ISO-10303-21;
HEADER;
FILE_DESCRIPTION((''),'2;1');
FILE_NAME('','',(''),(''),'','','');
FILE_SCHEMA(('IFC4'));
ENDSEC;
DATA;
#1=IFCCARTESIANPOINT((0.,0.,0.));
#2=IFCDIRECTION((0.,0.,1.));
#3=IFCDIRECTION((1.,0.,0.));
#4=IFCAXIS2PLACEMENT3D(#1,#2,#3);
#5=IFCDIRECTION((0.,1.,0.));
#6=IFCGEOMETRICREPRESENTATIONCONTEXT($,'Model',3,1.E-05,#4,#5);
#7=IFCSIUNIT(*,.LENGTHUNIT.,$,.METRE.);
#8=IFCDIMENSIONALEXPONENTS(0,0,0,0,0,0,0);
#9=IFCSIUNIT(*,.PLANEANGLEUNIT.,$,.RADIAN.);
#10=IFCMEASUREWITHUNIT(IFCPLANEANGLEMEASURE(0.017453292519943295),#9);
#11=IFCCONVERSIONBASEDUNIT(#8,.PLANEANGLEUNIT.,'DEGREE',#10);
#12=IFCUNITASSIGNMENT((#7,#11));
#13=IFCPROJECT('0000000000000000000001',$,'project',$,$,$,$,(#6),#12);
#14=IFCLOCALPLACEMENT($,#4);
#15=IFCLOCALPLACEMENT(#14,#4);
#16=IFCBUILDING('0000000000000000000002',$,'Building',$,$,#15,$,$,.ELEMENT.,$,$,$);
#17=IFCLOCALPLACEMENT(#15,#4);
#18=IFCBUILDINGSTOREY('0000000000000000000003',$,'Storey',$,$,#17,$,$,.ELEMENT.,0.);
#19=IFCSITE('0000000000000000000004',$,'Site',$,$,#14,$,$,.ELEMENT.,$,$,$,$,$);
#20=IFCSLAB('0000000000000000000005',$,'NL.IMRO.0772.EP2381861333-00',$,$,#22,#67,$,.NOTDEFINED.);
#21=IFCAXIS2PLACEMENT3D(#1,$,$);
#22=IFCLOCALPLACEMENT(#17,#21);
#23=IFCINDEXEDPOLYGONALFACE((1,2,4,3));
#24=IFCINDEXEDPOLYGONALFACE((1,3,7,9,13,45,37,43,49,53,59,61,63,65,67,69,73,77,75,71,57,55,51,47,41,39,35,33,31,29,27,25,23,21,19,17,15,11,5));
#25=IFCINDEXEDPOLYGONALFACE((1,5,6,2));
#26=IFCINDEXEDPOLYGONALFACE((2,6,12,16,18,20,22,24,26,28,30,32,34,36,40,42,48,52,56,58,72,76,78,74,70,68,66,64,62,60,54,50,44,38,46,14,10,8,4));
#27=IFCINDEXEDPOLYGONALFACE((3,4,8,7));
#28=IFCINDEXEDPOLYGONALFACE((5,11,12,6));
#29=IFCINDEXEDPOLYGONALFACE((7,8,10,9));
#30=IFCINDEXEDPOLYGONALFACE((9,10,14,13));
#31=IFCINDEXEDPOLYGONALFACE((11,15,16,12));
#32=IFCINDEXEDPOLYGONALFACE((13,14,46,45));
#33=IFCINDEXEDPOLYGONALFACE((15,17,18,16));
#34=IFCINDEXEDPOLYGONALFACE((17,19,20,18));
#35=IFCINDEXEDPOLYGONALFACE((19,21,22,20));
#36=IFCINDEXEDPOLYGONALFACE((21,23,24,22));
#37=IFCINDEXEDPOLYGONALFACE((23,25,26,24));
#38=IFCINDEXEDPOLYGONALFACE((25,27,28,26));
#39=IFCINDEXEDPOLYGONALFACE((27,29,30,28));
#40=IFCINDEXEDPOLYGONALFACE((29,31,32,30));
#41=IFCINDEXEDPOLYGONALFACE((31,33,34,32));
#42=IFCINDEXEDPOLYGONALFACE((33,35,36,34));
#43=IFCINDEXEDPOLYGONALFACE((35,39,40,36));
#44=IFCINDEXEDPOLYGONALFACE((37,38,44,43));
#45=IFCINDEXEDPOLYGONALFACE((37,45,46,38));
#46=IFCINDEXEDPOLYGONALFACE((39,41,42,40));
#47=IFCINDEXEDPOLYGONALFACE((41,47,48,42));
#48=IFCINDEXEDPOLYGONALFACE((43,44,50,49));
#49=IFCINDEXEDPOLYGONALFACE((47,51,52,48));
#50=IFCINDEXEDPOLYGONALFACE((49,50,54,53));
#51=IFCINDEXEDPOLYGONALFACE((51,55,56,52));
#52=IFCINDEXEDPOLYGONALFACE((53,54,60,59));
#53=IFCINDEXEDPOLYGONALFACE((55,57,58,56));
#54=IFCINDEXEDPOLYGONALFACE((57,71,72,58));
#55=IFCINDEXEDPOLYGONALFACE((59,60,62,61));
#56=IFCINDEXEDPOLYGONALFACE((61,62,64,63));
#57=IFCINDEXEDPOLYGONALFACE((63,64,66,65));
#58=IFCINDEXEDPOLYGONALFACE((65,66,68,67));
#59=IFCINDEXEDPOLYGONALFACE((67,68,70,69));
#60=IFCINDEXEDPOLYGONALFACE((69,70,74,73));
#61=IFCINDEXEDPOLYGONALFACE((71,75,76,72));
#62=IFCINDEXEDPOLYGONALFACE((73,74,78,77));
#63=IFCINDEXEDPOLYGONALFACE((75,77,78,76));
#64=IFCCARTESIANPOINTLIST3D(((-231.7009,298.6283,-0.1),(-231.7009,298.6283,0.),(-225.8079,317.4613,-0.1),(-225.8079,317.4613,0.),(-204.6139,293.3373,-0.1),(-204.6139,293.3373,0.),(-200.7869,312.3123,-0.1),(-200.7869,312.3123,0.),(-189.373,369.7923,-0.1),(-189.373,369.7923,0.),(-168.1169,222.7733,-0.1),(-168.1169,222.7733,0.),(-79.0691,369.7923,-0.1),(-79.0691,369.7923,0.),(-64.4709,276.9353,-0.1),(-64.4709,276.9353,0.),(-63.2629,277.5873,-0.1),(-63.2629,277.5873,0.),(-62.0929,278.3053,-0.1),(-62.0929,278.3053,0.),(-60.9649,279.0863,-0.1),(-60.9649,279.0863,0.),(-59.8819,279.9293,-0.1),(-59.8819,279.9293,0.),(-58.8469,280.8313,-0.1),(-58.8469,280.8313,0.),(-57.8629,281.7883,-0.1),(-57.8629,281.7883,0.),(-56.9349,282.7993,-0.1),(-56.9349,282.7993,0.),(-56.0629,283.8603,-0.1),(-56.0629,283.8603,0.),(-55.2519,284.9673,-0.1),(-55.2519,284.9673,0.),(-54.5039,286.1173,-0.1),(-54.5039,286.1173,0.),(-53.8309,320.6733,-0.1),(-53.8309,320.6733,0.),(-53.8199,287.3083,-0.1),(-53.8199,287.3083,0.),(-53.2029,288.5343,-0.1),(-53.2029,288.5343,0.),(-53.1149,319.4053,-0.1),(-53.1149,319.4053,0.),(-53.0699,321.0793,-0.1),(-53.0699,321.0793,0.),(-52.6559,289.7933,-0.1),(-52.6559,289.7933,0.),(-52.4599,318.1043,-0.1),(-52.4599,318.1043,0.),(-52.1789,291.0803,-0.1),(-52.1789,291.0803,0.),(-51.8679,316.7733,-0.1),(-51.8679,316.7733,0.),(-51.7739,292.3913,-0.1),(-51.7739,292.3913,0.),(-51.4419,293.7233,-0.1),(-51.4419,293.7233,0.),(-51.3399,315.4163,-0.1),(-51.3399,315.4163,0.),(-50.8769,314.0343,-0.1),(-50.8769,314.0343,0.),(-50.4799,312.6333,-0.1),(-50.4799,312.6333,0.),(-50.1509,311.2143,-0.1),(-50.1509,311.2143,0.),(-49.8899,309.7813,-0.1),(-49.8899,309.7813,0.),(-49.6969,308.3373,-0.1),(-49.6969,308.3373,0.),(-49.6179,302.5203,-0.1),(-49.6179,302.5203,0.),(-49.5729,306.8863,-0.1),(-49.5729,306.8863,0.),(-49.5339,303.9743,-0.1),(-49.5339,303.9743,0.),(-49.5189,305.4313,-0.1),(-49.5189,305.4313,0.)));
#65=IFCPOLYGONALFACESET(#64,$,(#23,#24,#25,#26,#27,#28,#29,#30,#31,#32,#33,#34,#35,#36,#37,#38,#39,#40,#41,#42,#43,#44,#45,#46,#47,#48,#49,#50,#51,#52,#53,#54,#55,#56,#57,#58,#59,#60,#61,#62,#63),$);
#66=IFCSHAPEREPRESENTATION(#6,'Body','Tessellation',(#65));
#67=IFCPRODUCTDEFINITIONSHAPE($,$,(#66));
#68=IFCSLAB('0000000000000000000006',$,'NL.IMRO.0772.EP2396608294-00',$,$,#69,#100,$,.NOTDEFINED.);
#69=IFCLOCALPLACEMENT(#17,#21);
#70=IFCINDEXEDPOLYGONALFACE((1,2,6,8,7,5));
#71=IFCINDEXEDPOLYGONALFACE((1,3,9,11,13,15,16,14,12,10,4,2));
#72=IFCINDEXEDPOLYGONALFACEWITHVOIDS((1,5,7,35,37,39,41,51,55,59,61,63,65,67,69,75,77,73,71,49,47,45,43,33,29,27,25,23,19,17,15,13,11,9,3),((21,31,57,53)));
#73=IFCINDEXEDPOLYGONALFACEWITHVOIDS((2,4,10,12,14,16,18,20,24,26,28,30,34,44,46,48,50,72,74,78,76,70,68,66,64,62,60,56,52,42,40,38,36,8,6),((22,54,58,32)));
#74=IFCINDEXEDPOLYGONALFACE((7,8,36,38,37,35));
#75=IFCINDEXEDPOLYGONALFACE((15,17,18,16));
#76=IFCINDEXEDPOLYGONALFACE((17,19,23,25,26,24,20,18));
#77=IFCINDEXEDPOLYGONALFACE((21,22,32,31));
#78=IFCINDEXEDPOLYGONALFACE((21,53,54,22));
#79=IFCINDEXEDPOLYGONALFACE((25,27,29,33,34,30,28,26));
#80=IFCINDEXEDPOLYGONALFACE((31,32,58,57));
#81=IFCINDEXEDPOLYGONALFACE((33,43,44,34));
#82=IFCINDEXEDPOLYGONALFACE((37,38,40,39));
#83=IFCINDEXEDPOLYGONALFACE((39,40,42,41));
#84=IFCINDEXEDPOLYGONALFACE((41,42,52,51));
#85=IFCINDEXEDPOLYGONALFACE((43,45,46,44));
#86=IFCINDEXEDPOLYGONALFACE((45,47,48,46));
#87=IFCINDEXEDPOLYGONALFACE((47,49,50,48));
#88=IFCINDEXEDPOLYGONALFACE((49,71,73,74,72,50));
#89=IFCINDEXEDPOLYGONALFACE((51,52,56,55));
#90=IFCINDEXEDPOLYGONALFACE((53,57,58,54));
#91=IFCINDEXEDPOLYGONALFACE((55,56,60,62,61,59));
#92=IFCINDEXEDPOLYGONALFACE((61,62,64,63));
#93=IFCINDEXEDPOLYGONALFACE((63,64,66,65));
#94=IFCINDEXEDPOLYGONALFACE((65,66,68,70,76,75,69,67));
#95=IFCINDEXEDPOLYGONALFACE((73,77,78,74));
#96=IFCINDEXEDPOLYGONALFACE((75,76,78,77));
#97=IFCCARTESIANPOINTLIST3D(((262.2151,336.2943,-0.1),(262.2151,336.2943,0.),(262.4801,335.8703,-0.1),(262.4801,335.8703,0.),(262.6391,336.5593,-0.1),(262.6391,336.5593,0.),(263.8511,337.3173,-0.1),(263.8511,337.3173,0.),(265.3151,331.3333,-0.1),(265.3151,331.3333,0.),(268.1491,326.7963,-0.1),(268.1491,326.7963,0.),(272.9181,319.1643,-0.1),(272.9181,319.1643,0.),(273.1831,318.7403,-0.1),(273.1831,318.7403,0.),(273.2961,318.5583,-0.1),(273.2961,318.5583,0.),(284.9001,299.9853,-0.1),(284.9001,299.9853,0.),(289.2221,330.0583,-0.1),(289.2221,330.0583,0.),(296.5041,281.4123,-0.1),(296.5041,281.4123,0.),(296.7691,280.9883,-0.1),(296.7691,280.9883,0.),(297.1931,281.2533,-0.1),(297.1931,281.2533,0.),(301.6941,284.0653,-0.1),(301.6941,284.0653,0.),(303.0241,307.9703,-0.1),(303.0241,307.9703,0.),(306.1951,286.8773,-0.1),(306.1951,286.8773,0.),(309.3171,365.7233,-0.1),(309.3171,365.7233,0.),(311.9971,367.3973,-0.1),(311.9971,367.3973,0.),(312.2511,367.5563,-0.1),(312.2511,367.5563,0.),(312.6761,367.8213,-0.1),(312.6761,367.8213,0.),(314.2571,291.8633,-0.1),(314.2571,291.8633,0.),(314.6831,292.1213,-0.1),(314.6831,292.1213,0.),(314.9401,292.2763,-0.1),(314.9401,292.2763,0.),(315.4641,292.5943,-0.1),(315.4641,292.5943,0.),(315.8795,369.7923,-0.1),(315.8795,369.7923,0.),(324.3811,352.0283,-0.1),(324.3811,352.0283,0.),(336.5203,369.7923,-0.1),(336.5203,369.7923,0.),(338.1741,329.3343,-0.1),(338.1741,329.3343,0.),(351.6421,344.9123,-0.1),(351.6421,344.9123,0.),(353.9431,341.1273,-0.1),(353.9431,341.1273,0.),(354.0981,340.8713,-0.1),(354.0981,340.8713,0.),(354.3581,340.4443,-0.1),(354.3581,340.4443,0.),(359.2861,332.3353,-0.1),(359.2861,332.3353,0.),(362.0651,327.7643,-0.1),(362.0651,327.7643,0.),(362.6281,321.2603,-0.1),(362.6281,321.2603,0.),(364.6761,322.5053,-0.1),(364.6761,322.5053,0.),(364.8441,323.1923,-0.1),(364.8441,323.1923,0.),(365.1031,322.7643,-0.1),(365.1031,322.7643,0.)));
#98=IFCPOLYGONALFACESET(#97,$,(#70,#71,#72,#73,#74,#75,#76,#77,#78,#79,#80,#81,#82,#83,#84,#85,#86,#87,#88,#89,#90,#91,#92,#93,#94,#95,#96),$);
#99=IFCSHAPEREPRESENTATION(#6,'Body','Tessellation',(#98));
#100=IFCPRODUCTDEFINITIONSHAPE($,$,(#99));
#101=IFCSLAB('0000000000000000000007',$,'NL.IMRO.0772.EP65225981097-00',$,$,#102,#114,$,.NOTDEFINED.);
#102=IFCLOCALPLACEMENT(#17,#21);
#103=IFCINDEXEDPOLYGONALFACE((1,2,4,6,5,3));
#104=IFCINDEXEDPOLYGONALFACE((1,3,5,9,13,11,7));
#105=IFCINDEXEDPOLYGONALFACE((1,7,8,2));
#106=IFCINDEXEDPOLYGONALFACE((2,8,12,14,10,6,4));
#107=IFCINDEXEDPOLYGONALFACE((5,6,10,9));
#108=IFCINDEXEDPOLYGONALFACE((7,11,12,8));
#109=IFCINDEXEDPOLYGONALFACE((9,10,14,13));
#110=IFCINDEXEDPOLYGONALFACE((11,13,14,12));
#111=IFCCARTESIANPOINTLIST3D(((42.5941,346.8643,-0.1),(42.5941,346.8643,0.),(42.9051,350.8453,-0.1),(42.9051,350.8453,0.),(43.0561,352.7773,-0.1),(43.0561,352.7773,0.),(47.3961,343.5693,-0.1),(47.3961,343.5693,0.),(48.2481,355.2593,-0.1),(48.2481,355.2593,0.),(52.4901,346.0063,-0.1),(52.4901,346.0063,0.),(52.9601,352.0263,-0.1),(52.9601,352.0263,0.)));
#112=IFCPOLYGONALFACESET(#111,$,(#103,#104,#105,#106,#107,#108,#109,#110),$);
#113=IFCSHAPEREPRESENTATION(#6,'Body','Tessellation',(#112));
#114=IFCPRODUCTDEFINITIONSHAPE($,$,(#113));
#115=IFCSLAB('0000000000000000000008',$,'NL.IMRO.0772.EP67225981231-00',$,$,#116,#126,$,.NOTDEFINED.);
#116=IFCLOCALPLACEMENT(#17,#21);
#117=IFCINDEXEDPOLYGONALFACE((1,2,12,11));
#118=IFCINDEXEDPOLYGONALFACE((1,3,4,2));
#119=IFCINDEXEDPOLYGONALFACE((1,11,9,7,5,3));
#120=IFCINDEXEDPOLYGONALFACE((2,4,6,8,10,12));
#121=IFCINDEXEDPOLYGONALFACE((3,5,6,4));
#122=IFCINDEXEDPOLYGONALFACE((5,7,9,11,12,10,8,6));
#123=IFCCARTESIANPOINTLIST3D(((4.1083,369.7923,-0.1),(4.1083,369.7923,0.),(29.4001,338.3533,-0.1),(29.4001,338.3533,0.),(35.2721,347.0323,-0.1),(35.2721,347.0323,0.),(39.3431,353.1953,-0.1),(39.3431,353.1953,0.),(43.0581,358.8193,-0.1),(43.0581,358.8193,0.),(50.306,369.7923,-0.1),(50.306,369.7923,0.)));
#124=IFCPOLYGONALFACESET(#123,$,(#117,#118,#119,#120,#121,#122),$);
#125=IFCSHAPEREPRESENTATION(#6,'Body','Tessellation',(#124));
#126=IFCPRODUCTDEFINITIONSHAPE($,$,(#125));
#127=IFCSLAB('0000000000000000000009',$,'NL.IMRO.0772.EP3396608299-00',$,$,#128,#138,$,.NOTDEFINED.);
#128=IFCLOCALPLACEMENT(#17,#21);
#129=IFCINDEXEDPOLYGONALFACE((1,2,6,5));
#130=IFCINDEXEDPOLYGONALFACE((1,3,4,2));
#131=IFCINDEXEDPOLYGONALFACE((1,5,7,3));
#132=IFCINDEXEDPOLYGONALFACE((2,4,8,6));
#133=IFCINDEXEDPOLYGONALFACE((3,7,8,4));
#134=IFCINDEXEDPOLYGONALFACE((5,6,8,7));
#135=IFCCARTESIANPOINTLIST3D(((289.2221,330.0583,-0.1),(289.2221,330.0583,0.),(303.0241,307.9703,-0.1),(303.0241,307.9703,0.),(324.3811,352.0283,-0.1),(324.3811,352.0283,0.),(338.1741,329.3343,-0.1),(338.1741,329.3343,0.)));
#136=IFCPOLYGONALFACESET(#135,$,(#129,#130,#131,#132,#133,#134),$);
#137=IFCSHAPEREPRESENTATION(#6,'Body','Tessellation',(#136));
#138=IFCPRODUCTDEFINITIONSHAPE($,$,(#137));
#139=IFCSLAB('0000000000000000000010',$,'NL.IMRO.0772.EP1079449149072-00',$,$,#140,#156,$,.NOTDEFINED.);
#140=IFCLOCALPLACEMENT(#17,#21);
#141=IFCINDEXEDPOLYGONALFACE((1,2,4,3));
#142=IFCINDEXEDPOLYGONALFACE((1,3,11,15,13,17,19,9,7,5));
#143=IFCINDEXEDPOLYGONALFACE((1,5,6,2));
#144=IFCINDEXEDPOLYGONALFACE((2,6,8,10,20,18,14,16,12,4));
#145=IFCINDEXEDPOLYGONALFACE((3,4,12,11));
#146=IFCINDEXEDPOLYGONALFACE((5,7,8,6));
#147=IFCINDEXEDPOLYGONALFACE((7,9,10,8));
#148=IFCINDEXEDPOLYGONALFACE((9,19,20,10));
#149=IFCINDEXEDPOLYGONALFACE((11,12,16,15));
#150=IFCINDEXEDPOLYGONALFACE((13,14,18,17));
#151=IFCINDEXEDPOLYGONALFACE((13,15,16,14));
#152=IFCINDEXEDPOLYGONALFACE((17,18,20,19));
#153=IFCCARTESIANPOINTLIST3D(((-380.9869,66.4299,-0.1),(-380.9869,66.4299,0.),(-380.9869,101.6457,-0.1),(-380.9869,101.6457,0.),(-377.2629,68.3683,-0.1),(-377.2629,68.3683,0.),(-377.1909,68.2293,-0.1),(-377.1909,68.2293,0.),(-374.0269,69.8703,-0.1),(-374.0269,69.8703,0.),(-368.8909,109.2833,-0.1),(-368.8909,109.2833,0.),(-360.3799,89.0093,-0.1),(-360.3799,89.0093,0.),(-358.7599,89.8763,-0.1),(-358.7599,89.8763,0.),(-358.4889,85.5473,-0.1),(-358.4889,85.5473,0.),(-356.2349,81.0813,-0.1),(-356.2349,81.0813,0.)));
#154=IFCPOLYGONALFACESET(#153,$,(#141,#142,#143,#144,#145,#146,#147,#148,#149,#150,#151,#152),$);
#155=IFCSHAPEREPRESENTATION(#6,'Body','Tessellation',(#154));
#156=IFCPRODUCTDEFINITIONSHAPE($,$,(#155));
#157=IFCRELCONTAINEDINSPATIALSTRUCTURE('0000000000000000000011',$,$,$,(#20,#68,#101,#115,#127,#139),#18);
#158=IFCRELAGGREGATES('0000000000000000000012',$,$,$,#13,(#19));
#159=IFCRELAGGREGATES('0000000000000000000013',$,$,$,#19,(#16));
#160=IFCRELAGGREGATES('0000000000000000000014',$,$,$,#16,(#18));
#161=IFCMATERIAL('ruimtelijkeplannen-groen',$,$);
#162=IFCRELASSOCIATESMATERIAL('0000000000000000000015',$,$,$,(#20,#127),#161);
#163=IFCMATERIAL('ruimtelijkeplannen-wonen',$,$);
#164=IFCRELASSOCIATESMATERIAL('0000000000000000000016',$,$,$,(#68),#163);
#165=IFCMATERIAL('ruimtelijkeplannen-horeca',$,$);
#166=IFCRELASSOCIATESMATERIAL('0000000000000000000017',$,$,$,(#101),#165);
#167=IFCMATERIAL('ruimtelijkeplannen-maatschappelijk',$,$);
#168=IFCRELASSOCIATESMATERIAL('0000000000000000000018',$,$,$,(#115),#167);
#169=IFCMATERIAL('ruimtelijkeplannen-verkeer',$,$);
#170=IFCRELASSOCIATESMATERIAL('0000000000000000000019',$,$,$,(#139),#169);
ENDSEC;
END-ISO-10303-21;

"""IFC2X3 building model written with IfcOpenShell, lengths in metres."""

from ifc_helpers import new_model, entity, si_unit, converted_unit, direction, frame, origin_with_axes, place, context, project, spatial, polyline, outline, extrude, material, element, save


model = new_model("IFC2X3")

# Units and contexts
model_context = context("Model", 3, precision=1e-05, world=origin_with_axes(), true_north=direction((0.0, 1.0, 0.0)))
ifc_project = project(units=[si_unit("LENGTHUNIT", "METRE"), converted_unit("PLANEANGLEUNIT", "DEGREE", entity("IfcPlaneAngleMeasure", 0.017453292519943295), si_unit("PLANEANGLEUNIT", "RADIAN"), dimensions=[0, 0, 0, 0, 0, 0, 0])], contexts=[model_context])

# Site, building, storey
site_placement = place(None, origin_with_axes())
site = spatial("IfcSite", under=ifc_project, at=site_placement, Name="Site", CompositionType="ELEMENT")
building_placement = place(site_placement, origin_with_axes())
building = spatial("IfcBuilding", under=site, at=building_placement, Name="Building", CompositionType="ELEMENT")
storey_placement = place(building_placement, origin_with_axes())
storey = spatial("IfcBuildingStorey", under=building, at=storey_placement, Name="Storey", CompositionType="ELEMENT", Elevation=0.0)

# Slabs
ifc_material_1 = material(Name="ruimtelijkeplannen-wonen")
ifc_material_2 = material(Name="ruimtelijkeplannen-groen")
slab_1_placement = place(storey_placement, frame((0.0, 0.0, -0.1), z_axis=(0.0, 0.0, 1.0), x_axis=(1.0, 0.0, 0.0)))
element("IfcSlab", 1, at=slab_1_placement, inside=storey, material=ifc_material_2, Name="NL.IMRO.0772.EP2381861333-00", PredefinedType="NOTDEFINED", context=model_context, shape_type="SweptSolid", body=[
    extrude(outline(polyline([(-53.0699, 321.0793), (-53.8309, 320.6733), (-53.1149, 319.4053), (-52.4599, 318.1043), (-51.8679, 316.7733), (-51.3399, 315.4163), (-50.8769, 314.0343), (-50.4799, 312.6333), (-50.1509, 311.2143), (-49.8899, 309.7813), (-49.6969, 308.3373), (-49.5729, 306.8863), (-49.5189, 305.4313), (-49.5339, 303.9743), (-49.6179, 302.5203), (-51.4419, 293.7233), (-51.7739, 292.3913), (-52.1789, 291.0803), (-52.6559, 289.7933), (-53.2029, 288.5343), (-53.8199, 287.3083), (-54.5039, 286.1173), (-55.2519, 284.9673), (-56.0629, 283.8603), (-56.9349, 282.7993), (-57.8629, 281.7883), (-58.8469, 280.8313), (-59.8819, 279.9293), (-60.9649, 279.0863), (-62.0929, 278.3053), (-63.2629, 277.5873), (-64.4709, 276.9353), (-168.1169, 222.7733), (-204.6139, 293.3373), (-231.7009, 298.6283), (-225.8079, 317.4613), (-200.7869, 312.3123), (-189.373, 369.7923), (-79.0691, 369.7923), (-53.0699, 321.0793)])), origin_with_axes(), (0.0, 0.0, 1.0), 0.1),
])
ifc_material_3 = material(Name="ruimtelijkeplannen-verkeer")
slab_2_placement = place(storey_placement, frame((0.0, 0.0, -0.1), z_axis=(0.0, 0.0, 1.0), x_axis=(1.0, 0.0, 0.0)))
element("IfcSlab", 2, at=slab_2_placement, inside=storey, material=ifc_material_1, Name="NL.IMRO.0772.EP2396608294-00", PredefinedType="NOTDEFINED", context=model_context, shape_type="SweptSolid", body=[
    extrude(outline(polyline([(351.6421, 344.9123), (353.9431, 341.1273), (354.0981, 340.8713), (354.3581, 340.4443), (359.2861, 332.3353), (362.0651, 327.7643), (364.8441, 323.1923), (365.1031, 322.7643), (364.6761, 322.5053), (362.6281, 321.2603), (315.4641, 292.5943), (314.9401, 292.2763), (314.6831, 292.1213), (314.2571, 291.8633), (306.1951, 286.8773), (301.6941, 284.0653), (297.1931, 281.2533), (296.7691, 280.9883), (296.5041, 281.4123), (284.9001, 299.9853), (273.2961, 318.5583), (273.1831, 318.7403), (272.9181, 319.1643), (268.1491, 326.7963), (265.3151, 331.3333), (262.4801, 335.8703), (262.2151, 336.2943), (262.6391, 336.5593), (263.8511, 337.3173), (309.3171, 365.7233), (311.9971, 367.3973), (312.2511, 367.5563), (312.6761, 367.8213), (315.8795, 369.7923), (336.5203, 369.7923), (351.6421, 344.9123)]), holes=[polyline([(303.0241, 307.9703), (338.1741, 329.3343), (324.3811, 352.0283), (289.2221, 330.0583), (303.0241, 307.9703)])]), origin_with_axes(), (0.0, 0.0, 1.0), 0.1),
])
ifc_material_4 = material(Name="ruimtelijkeplannen-horeca")
slab_3_placement = place(storey_placement, frame((0.0, 0.0, -0.1), z_axis=(0.0, 0.0, 1.0), x_axis=(1.0, 0.0, 0.0)))
element("IfcSlab", 3, at=slab_3_placement, inside=storey, material=ifc_material_4, Name="NL.IMRO.0772.EP65225981097-00", PredefinedType="NOTDEFINED", context=model_context, shape_type="SweptSolid", body=[
    extrude(outline(polyline([(48.2481, 355.2593), (52.9601, 352.0263), (52.4901, 346.0063), (47.3961, 343.5693), (42.5941, 346.8643), (42.9051, 350.8453), (43.0561, 352.7773), (48.2481, 355.2593)])), origin_with_axes(), (0.0, 0.0, 1.0), 0.1),
])
ifc_material_5 = material(Name="ruimtelijkeplannen-maatschappelijk")
slab_4_placement = place(storey_placement, frame((0.0, 0.0, -0.1), z_axis=(0.0, 0.0, 1.0), x_axis=(1.0, 0.0, 0.0)))
element("IfcSlab", 4, at=slab_4_placement, inside=storey, material=ifc_material_5, Name="NL.IMRO.0772.EP67225981231-00", PredefinedType="NOTDEFINED", context=model_context, shape_type="SweptSolid", body=[
    extrude(outline(polyline([(43.0581, 358.8193), (39.3431, 353.1953), (35.2721, 347.0323), (29.4001, 338.3533), (4.1083, 369.7923), (50.306, 369.7923), (43.0581, 358.8193)])), origin_with_axes(), (0.0, 0.0, 1.0), 0.1),
])
slab_5_placement = place(storey_placement, frame((0.0, 0.0, -0.1), z_axis=(0.0, 0.0, 1.0), x_axis=(1.0, 0.0, 0.0)))
element("IfcSlab", 5, at=slab_5_placement, inside=storey, material=ifc_material_2, Name="NL.IMRO.0772.EP3396608299-00", PredefinedType="NOTDEFINED", context=model_context, shape_type="SweptSolid", body=[
    extrude(outline(polyline([(289.2221, 330.0583), (324.3811, 352.0283), (338.1741, 329.3343), (303.0241, 307.9703), (289.2221, 330.0583)])), origin_with_axes(), (0.0, 0.0, 1.0), 0.1),
])
slab_6_placement = place(storey_placement, frame((0.0, 0.0, -0.1), z_axis=(0.0, 0.0, 1.0), x_axis=(1.0, 0.0, 0.0)))
element("IfcSlab", 6, at=slab_6_placement, inside=storey, material=ifc_material_3, Name="NL.IMRO.0772.EP1079449149072-00", PredefinedType="NOTDEFINED", context=model_context, shape_type="SweptSolid", body=[
    extrude(outline(polyline([(-368.8909, 109.2833), (-358.7599, 89.8763), (-360.3799, 89.0093), (-358.4889, 85.5473), (-356.2349, 81.0813), (-374.0269, 69.8703), (-377.1909, 68.2293), (-377.2629, 68.3683), (-380.9869, 66.4299), (-380.9869, 101.6457), (-368.8909, 109.2833)])), origin_with_axes(), (0.0, 0.0, 1.0), 0.1),
])

save(model, "model.ifc")
